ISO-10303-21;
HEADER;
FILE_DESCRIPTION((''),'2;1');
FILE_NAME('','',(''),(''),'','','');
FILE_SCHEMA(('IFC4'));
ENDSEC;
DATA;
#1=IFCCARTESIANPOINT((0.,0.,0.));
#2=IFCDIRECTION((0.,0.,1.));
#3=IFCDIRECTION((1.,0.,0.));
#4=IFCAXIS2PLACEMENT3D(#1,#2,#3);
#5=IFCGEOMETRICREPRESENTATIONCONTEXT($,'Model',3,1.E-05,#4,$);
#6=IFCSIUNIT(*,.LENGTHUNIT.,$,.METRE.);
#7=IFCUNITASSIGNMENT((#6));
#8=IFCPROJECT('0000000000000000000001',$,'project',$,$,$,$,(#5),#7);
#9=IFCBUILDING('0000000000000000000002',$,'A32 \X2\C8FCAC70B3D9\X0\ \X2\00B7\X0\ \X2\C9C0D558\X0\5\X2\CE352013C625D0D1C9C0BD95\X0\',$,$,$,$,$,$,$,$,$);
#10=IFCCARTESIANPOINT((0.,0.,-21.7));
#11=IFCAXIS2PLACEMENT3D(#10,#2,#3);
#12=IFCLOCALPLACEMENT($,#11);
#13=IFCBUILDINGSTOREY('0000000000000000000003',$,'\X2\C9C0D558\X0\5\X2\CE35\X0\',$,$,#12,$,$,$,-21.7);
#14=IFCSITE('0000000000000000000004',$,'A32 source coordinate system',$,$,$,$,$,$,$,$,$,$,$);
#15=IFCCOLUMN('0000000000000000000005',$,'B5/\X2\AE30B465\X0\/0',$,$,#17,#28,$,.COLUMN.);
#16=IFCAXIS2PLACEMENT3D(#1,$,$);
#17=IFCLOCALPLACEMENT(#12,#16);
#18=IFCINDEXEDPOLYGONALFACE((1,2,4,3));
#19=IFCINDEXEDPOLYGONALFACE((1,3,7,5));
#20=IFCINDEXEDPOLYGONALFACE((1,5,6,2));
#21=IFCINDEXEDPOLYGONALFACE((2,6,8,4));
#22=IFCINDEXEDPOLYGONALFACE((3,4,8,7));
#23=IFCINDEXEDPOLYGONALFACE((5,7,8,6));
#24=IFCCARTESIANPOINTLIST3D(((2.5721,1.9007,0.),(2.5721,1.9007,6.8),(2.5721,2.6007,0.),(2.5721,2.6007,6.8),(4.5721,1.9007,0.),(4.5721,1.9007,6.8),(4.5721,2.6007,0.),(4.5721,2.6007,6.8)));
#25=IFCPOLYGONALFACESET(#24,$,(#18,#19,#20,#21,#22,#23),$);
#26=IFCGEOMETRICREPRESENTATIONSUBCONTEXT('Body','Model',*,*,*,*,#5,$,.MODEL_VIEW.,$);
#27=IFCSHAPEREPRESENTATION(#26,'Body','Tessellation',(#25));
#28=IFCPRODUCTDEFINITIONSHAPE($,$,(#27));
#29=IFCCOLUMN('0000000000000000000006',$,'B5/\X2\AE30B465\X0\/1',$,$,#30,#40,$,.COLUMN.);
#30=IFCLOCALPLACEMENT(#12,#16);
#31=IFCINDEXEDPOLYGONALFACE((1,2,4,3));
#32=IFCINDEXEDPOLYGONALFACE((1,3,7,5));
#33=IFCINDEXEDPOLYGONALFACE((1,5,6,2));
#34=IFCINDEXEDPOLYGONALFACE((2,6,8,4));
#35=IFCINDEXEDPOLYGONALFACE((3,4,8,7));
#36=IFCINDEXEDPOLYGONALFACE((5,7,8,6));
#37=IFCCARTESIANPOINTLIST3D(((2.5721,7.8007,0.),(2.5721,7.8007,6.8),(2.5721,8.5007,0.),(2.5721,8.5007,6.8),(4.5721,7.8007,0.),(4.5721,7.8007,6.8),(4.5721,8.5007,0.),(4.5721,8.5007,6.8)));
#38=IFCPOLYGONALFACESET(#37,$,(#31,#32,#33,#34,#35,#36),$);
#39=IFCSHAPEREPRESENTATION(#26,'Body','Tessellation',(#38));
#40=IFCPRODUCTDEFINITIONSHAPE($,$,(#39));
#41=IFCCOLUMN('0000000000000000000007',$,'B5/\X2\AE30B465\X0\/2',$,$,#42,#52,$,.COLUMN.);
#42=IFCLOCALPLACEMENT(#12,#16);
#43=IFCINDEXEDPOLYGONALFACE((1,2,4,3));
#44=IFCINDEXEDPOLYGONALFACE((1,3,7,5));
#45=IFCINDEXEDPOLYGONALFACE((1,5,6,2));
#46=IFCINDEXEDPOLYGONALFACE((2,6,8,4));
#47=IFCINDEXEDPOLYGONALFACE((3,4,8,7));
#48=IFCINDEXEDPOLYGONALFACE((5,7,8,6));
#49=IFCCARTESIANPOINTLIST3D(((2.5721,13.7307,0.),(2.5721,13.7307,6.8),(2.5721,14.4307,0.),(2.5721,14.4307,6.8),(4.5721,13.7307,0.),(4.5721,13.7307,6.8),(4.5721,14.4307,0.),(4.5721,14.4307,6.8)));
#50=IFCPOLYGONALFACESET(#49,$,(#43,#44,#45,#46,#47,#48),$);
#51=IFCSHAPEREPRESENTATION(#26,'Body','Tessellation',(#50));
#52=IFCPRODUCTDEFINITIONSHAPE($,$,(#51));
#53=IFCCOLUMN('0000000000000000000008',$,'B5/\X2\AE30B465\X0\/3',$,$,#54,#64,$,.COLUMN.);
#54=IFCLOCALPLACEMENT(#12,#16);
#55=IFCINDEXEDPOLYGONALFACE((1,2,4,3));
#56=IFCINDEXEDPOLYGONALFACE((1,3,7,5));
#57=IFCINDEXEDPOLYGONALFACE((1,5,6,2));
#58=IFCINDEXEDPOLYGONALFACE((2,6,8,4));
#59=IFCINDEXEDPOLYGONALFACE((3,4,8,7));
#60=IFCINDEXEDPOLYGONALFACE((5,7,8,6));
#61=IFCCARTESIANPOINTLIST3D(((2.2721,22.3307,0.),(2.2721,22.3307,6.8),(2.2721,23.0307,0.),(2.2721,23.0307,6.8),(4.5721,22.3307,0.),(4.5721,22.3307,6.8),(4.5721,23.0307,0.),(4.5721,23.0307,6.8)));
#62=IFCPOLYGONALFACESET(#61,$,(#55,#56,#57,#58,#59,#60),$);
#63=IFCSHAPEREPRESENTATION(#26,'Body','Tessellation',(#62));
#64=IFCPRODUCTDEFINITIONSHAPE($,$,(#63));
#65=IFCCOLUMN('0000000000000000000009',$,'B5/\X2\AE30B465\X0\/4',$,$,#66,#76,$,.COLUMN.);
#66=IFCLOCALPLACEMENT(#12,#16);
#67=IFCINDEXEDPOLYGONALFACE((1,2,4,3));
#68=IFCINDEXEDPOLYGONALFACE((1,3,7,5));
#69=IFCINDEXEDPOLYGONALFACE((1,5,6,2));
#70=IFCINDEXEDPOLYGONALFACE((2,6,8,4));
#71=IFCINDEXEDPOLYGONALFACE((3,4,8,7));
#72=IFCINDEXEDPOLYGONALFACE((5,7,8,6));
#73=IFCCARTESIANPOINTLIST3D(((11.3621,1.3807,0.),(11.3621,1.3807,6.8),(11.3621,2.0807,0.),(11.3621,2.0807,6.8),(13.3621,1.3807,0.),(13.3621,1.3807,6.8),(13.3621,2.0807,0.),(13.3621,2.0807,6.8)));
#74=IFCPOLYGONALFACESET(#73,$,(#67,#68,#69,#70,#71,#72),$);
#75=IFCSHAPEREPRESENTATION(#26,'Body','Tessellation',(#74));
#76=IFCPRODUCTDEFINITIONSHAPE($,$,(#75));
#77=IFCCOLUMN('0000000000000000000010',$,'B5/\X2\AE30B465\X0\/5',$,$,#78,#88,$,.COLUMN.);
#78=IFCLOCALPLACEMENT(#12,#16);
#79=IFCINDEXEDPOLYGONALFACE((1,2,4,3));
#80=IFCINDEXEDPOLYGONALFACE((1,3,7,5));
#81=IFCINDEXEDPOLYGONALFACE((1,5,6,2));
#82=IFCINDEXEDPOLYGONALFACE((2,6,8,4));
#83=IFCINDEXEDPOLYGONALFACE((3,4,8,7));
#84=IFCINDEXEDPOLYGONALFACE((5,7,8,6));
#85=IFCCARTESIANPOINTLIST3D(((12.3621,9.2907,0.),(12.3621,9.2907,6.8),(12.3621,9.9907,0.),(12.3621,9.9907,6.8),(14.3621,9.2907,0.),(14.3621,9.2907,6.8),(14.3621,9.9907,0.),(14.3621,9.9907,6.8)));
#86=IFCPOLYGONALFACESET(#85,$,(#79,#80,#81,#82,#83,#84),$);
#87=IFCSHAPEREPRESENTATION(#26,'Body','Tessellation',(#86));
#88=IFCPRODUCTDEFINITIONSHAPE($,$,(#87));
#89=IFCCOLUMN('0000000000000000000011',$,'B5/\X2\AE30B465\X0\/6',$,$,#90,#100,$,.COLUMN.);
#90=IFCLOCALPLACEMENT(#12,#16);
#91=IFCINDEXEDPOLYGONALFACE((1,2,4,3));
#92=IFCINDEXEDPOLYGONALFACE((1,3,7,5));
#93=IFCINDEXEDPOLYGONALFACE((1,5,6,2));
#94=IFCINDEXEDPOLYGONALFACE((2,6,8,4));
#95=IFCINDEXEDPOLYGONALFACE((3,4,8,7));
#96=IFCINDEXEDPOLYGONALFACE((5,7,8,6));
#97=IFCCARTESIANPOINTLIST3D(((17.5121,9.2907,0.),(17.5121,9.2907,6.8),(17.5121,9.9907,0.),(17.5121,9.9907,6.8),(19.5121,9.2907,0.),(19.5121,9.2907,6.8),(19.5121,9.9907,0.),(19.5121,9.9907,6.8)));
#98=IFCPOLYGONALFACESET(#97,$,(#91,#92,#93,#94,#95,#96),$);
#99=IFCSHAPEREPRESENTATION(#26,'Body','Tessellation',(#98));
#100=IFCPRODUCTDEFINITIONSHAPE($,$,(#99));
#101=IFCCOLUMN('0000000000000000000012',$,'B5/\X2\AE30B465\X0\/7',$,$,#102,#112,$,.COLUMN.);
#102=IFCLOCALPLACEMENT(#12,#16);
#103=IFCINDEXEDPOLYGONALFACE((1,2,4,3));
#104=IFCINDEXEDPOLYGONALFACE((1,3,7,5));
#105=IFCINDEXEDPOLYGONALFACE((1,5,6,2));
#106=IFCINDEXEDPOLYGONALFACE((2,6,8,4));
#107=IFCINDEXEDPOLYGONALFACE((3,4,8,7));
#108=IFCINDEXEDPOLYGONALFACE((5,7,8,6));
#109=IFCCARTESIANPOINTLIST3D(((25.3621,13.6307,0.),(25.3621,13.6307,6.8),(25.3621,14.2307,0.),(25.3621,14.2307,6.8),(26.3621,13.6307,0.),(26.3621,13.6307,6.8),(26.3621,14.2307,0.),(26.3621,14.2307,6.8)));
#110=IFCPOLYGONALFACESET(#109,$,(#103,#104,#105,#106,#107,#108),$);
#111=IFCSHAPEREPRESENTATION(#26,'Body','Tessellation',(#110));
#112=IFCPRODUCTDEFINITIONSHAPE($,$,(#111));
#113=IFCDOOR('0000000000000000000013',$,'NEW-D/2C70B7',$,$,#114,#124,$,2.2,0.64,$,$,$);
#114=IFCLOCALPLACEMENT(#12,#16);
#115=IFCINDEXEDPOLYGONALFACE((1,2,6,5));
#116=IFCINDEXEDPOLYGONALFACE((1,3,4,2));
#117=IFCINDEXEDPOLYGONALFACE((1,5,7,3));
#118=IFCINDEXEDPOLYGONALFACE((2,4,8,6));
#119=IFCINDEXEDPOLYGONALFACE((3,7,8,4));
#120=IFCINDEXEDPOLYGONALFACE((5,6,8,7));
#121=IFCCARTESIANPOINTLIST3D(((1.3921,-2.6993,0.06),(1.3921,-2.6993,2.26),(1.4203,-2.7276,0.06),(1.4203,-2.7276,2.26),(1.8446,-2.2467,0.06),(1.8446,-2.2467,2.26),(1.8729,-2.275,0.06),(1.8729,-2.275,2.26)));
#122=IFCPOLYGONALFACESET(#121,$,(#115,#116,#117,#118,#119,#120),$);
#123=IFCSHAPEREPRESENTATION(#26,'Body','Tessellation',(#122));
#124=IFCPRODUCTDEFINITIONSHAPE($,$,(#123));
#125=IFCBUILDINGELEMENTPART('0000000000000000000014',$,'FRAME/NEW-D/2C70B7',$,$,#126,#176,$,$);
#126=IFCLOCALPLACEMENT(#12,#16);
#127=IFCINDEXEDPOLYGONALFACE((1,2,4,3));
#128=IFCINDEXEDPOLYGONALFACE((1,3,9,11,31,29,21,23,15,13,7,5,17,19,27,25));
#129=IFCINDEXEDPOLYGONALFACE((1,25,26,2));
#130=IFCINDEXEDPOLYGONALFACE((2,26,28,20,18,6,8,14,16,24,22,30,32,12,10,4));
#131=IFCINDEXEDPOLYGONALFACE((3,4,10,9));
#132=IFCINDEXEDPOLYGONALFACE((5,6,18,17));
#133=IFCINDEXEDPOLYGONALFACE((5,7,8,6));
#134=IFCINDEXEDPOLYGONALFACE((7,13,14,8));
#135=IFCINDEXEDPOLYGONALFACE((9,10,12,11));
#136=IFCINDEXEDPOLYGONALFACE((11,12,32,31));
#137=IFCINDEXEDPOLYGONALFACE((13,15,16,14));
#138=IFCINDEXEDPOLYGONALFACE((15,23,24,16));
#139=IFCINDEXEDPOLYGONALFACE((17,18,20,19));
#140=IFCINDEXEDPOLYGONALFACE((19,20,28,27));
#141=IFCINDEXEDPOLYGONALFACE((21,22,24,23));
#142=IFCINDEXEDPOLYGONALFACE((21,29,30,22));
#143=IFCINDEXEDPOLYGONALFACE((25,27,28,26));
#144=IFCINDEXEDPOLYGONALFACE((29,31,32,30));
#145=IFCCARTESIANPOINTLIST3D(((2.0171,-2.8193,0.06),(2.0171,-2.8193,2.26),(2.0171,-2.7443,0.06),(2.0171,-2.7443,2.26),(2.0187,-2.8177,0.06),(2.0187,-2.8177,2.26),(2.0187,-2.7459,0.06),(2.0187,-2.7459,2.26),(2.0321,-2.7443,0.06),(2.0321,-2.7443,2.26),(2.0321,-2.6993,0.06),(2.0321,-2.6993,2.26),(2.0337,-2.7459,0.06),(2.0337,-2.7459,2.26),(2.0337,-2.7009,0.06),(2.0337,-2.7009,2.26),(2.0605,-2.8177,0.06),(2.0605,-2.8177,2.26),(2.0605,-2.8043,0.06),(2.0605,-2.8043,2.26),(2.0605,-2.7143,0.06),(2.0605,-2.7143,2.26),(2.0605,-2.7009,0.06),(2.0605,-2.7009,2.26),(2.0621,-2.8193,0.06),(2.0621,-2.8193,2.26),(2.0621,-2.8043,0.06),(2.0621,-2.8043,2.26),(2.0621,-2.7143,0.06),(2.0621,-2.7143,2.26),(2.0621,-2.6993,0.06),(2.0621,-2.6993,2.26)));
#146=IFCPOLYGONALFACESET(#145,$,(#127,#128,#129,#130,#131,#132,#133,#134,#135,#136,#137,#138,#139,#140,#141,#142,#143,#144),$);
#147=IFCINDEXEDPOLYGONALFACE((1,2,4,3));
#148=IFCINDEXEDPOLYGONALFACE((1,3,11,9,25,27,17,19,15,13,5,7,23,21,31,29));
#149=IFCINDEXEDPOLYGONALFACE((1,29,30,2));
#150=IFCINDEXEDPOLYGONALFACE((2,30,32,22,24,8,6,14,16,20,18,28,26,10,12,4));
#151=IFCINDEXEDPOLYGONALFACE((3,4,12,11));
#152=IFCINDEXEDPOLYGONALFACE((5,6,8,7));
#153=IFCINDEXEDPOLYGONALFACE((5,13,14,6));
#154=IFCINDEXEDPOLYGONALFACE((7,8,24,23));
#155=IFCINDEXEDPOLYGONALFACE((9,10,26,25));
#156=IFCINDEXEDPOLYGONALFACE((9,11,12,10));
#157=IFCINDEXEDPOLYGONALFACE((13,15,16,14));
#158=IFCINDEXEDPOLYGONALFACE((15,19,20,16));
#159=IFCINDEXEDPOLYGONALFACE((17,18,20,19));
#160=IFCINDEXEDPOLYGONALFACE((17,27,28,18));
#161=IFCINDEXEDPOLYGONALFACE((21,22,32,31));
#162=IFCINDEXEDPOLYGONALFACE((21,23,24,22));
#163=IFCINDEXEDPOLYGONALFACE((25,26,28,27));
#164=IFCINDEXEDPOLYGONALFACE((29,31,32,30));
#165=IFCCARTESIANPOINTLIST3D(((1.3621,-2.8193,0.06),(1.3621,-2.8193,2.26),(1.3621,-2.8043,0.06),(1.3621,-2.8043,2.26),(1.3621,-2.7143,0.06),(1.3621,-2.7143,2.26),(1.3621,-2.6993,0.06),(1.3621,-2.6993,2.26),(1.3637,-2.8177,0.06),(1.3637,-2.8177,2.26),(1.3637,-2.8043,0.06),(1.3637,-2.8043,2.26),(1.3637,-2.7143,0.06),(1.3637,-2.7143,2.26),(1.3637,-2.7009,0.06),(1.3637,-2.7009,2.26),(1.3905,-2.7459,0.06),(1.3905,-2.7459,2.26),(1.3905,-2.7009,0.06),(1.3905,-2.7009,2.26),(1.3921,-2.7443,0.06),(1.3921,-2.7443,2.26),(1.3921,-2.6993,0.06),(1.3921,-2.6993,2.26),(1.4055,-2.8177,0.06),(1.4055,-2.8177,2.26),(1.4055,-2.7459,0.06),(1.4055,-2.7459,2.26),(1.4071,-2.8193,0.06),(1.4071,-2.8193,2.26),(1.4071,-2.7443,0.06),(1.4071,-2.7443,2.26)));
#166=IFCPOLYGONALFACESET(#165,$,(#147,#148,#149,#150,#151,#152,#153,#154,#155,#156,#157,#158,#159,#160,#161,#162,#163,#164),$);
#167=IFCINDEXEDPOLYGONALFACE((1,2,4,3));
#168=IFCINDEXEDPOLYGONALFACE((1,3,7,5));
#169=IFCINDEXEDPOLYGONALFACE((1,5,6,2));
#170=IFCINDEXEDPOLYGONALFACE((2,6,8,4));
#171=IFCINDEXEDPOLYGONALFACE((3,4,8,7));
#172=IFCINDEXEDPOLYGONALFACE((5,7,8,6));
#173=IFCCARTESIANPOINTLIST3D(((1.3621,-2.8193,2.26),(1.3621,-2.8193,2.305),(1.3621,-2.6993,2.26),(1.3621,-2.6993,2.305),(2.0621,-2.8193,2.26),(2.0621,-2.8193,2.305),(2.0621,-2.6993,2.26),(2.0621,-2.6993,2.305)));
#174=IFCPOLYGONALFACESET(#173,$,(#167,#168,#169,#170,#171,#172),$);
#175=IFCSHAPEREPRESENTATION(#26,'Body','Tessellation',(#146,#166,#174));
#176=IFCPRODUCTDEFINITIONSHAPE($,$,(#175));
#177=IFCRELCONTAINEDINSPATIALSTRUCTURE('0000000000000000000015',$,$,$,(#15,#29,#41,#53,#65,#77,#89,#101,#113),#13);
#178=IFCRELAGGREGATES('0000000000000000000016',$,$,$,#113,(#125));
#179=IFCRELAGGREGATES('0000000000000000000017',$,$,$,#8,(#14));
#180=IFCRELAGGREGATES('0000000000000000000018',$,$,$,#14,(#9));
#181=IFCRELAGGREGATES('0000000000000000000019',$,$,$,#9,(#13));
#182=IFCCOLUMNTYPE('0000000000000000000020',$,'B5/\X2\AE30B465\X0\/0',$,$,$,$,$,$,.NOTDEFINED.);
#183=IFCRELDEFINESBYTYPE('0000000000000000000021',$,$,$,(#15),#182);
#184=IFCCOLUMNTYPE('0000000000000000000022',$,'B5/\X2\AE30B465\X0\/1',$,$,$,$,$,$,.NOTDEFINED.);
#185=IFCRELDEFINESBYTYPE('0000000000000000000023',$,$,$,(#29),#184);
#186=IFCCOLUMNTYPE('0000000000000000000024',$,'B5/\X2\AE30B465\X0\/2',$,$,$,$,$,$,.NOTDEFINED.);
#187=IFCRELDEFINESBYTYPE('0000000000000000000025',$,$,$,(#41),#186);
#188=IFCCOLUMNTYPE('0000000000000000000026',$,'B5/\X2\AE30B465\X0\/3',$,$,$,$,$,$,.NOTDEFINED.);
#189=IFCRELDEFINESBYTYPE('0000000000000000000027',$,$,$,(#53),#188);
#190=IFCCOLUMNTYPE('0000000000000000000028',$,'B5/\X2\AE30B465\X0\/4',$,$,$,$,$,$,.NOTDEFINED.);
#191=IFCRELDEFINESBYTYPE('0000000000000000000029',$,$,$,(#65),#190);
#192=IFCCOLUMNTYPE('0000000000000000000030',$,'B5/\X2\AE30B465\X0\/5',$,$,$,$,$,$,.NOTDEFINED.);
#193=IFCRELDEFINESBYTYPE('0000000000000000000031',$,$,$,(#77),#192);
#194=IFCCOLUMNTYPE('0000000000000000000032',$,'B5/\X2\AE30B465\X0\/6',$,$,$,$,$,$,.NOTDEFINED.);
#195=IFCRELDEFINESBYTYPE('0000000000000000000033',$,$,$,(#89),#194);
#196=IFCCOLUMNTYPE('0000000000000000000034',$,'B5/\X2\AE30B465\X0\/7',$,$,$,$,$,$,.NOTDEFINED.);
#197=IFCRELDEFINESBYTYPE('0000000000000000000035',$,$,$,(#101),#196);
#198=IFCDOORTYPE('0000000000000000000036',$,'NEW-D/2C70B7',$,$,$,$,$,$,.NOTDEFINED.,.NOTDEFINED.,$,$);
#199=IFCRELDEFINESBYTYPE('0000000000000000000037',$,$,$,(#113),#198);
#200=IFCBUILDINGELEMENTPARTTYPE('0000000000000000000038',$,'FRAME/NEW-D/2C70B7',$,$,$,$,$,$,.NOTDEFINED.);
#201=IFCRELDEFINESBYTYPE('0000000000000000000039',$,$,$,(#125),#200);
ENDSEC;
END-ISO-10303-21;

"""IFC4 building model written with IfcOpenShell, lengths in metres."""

from ifc_helpers import new_model, si_unit, frame, origin, origin_with_axes, place, context, subcontext, project, spatial, polyline, outline, extrude, source, transform, mapped, type_object, type_shapes, element, aggregate, save


model = new_model("IFC4")

# Units and contexts
model_context = context("Model", 3, precision=1e-05, world=origin_with_axes())
body_context = subcontext(model_context, "Body", "Model", "MODEL_VIEW")
ifc_project = project(units=[si_unit("LENGTHUNIT", "METRE")], contexts=[model_context])

# Site, building, storey
site = spatial("IfcSite", under=ifc_project, Name="A32 source coordinate system")
building = spatial("IfcBuilding", under=site, Name="A32 주거동 · 지하5층–옥탑지붕")
storey_placement = place(None, frame((0.0, 0.0, -21.7), z_axis=(0.0, 0.0, 1.0), x_axis=(1.0, 0.0, 0.0)))
storey = spatial("IfcBuildingStorey", under=building, at=storey_placement, Name="지하5층", Elevation=-21.7)

# Columns
column_type_1 = type_object("IfcColumnType", Name="B5/기둥/0", PredefinedType="NOTDEFINED")
shared_shape_1 = source(origin(), body_context, "Body", "SweptSolid", [
    extrude(outline(polyline([(4.5721, 1.9007), (2.5721, 1.9007), (2.5721, 2.6007), (4.5721, 2.6007), (4.5721, 1.9007)])), origin(), (0.0, 0.0, 1.0), 6.8),
])
type_shapes(column_type_1, [shared_shape_1])
column_1_placement = place(storey_placement, origin_with_axes())
element("IfcColumn", 1, at=column_1_placement, inside=storey, type_object=column_type_1, Name="B5/기둥/0", PredefinedType="COLUMN", context=body_context, shape_type="MappedRepresentation", body=[
    mapped(shared_shape_1, transform((0.0, 0.0, 0.0), scale=1.0)),
])
column_type_2 = type_object("IfcColumnType", Name="B5/기둥/1", PredefinedType="NOTDEFINED")
shared_shape_2 = source(origin(), body_context, "Body", "SweptSolid", [
    extrude(outline(polyline([(4.5721, 8.5007), (4.5721, 7.8007), (2.5721, 7.8007), (2.5721, 8.5007), (4.5721, 8.5007)])), origin(), (0.0, 0.0, 1.0), 6.8),
])
type_shapes(column_type_2, [shared_shape_2])
column_2_placement = place(storey_placement, origin_with_axes())
element("IfcColumn", 2, at=column_2_placement, inside=storey, type_object=column_type_2, Name="B5/기둥/1", PredefinedType="COLUMN", context=body_context, shape_type="MappedRepresentation", body=[
    mapped(shared_shape_2, transform((0.0, 0.0, 0.0), scale=1.0)),
])
column_type_3 = type_object("IfcColumnType", Name="B5/기둥/2", PredefinedType="NOTDEFINED")
shared_shape_3 = source(origin(), body_context, "Body", "SweptSolid", [
    extrude(outline(polyline([(2.5721, 14.4307), (4.5721, 14.4307), (4.5721, 13.7307), (2.5721, 13.7307), (2.5721, 14.4307)])), origin(), (0.0, 0.0, 1.0), 6.8),
])
type_shapes(column_type_3, [shared_shape_3])
column_3_placement = place(storey_placement, origin_with_axes())
element("IfcColumn", 3, at=column_3_placement, inside=storey, type_object=column_type_3, Name="B5/기둥/2", PredefinedType="COLUMN", context=body_context, shape_type="MappedRepresentation", body=[
    mapped(shared_shape_3, transform((0.0, 0.0, 0.0), scale=1.0)),
])
column_type_4 = type_object("IfcColumnType", Name="B5/기둥/3", PredefinedType="NOTDEFINED")
shared_shape_4 = source(origin(), body_context, "Body", "SweptSolid", [
    extrude(outline(polyline([(4.5721, 22.3307), (2.2721, 22.3307), (2.2721, 23.0307), (4.5721, 23.0307), (4.5721, 22.3307)])), origin(), (0.0, 0.0, 1.0), 6.8),
])
type_shapes(column_type_4, [shared_shape_4])
column_4_placement = place(storey_placement, origin_with_axes())
element("IfcColumn", 4, at=column_4_placement, inside=storey, type_object=column_type_4, Name="B5/기둥/3", PredefinedType="COLUMN", context=body_context, shape_type="MappedRepresentation", body=[
    mapped(shared_shape_4, transform((0.0, 0.0, 0.0), scale=1.0)),
])
column_type_5 = type_object("IfcColumnType", Name="B5/기둥/4", PredefinedType="NOTDEFINED")
shared_shape_5 = source(origin(), body_context, "Body", "SweptSolid", [
    extrude(outline(polyline([(11.3621, 2.0807), (13.3621, 2.0807), (13.3621, 1.3807), (11.3621, 1.3807), (11.3621, 2.0807)])), origin(), (0.0, 0.0, 1.0), 6.8),
])
type_shapes(column_type_5, [shared_shape_5])
column_5_placement = place(storey_placement, origin_with_axes())
element("IfcColumn", 5, at=column_5_placement, inside=storey, type_object=column_type_5, Name="B5/기둥/4", PredefinedType="COLUMN", context=body_context, shape_type="MappedRepresentation", body=[
    mapped(shared_shape_5, transform((0.0, 0.0, 0.0), scale=1.0)),
])
column_type_6 = type_object("IfcColumnType", Name="B5/기둥/5", PredefinedType="NOTDEFINED")
shared_shape_6 = source(origin(), body_context, "Body", "SweptSolid", [
    extrude(outline(polyline([(12.3621, 9.2907), (12.3621, 9.9907), (14.3621, 9.9907), (14.3621, 9.2907), (12.3621, 9.2907)])), origin(), (0.0, 0.0, 1.0), 6.8),
])
type_shapes(column_type_6, [shared_shape_6])
column_6_placement = place(storey_placement, origin_with_axes())
element("IfcColumn", 6, at=column_6_placement, inside=storey, type_object=column_type_6, Name="B5/기둥/5", PredefinedType="COLUMN", context=body_context, shape_type="MappedRepresentation", body=[
    mapped(shared_shape_6, transform((0.0, 0.0, 0.0), scale=1.0)),
])
column_type_7 = type_object("IfcColumnType", Name="B5/기둥/6", PredefinedType="NOTDEFINED")
shared_shape_7 = source(origin(), body_context, "Body", "SweptSolid", [
    extrude(outline(polyline([(17.5121, 9.9907), (19.5121, 9.9907), (19.5121, 9.2907), (17.5121, 9.2907), (17.5121, 9.9907)])), origin(), (0.0, 0.0, 1.0), 6.8),
])
type_shapes(column_type_7, [shared_shape_7])
column_7_placement = place(storey_placement, origin_with_axes())
element("IfcColumn", 7, at=column_7_placement, inside=storey, type_object=column_type_7, Name="B5/기둥/6", PredefinedType="COLUMN", context=body_context, shape_type="MappedRepresentation", body=[
    mapped(shared_shape_7, transform((0.0, 0.0, 0.0), scale=1.0)),
])
column_type_8 = type_object("IfcColumnType", Name="B5/기둥/7", PredefinedType="NOTDEFINED")
shared_shape_8 = source(origin(), body_context, "Body", "SweptSolid", [
    extrude(outline(polyline([(25.3621, 14.2307), (26.3621, 14.2307), (26.3621, 13.6307), (25.3621, 13.6307), (25.3621, 14.2307)])), origin(), (0.0, 0.0, 1.0), 6.8),
])
type_shapes(column_type_8, [shared_shape_8])
column_8_placement = place(storey_placement, origin_with_axes())
element("IfcColumn", 8, at=column_8_placement, inside=storey, type_object=column_type_8, Name="B5/기둥/7", PredefinedType="COLUMN", context=body_context, shape_type="MappedRepresentation", body=[
    mapped(shared_shape_8, transform((0.0, 0.0, 0.0), scale=1.0)),
])

# Door
door_type_1 = type_object("IfcDoorType", Name="NEW-D/2C70B7", OperationType="NOTDEFINED", PredefinedType="NOTDEFINED")
shared_shape_9 = source(origin(), body_context, "Body", "SweptSolid", [
    extrude(outline(polyline([(1.8729, -2.275), (1.4203, -2.7276), (1.3921, -2.6993), (1.8446, -2.2467), (1.8729, -2.275)])), frame((0.0, 0.0, 0.06)), (0.0, 0.0, 1.0), 2.2),
])
type_shapes(door_type_1, [shared_shape_9])
door_1_placement = place(storey_placement, origin_with_axes())
door_1 = element("IfcDoor", 9, at=door_1_placement, inside=storey, type_object=door_type_1, Name="NEW-D/2C70B7", OverallHeight=2.2, OverallWidth=0.64, context=body_context, shape_type="MappedRepresentation", body=[
    mapped(shared_shape_9, transform((0.0, 0.0, 0.0), scale=1.0)),
])

# Building element part
building_element_part_type_1 = type_object("IfcBuildingElementPartType", Name="FRAME/NEW-D/2C70B7", PredefinedType="NOTDEFINED")
shared_shape_10 = source(origin(), body_context, "Body", "SweptSolid", [
    extrude(outline(polyline([(2.0337, -2.7009), (2.0337, -2.7459), (2.0187, -2.7459), (2.0187, -2.8177), (2.0605, -2.8177), (2.0605, -2.8043), (2.0621, -2.8043), (2.0621, -2.8193), (2.0171, -2.8193), (2.0171, -2.7443), (2.0321, -2.7443), (2.0321, -2.6993), (2.0621, -2.6993), (2.0621, -2.7143), (2.0605, -2.7143), (2.0605, -2.7009), (2.0337, -2.7009)])), frame((0.0, 0.0, 0.06)), (0.0, 0.0, 1.0), 2.2),
    extrude(outline(polyline([(1.3621, -2.6993), (1.3921, -2.6993), (1.3921, -2.7443), (1.4071, -2.7443), (1.4071, -2.8193), (1.3621, -2.8193), (1.3621, -2.8043), (1.3637, -2.8043), (1.3637, -2.8177), (1.4055, -2.8177), (1.4055, -2.7459), (1.3905, -2.7459), (1.3905, -2.7009), (1.3637, -2.7009), (1.3637, -2.7143), (1.3621, -2.7143), (1.3621, -2.6993)])), frame((0.0, 0.0, 0.06)), (0.0, 0.0, 1.0), 2.2),
    extrude(outline(polyline([(2.0621, -2.8193), (2.0621, -2.6993), (1.3621, -2.6993), (1.3621, -2.8193), (2.0621, -2.8193)])), frame((0.0, 0.0, 2.26)), (0.0, 0.0, 1.0), 0.045),
])
type_shapes(building_element_part_type_1, [shared_shape_10])
building_element_part_1_placement = place(door_1_placement, origin_with_axes())
building_element_part_1 = element("IfcBuildingElementPart", 10, at=building_element_part_1_placement, type_object=building_element_part_type_1, Name="FRAME/NEW-D/2C70B7", context=body_context, shape_type="MappedRepresentation", body=[
    mapped(shared_shape_10, transform((0.0, 0.0, 0.0), scale=1.0)),
])
aggregate(door_1, [building_element_part_1])

save(model, "model.ifc")
